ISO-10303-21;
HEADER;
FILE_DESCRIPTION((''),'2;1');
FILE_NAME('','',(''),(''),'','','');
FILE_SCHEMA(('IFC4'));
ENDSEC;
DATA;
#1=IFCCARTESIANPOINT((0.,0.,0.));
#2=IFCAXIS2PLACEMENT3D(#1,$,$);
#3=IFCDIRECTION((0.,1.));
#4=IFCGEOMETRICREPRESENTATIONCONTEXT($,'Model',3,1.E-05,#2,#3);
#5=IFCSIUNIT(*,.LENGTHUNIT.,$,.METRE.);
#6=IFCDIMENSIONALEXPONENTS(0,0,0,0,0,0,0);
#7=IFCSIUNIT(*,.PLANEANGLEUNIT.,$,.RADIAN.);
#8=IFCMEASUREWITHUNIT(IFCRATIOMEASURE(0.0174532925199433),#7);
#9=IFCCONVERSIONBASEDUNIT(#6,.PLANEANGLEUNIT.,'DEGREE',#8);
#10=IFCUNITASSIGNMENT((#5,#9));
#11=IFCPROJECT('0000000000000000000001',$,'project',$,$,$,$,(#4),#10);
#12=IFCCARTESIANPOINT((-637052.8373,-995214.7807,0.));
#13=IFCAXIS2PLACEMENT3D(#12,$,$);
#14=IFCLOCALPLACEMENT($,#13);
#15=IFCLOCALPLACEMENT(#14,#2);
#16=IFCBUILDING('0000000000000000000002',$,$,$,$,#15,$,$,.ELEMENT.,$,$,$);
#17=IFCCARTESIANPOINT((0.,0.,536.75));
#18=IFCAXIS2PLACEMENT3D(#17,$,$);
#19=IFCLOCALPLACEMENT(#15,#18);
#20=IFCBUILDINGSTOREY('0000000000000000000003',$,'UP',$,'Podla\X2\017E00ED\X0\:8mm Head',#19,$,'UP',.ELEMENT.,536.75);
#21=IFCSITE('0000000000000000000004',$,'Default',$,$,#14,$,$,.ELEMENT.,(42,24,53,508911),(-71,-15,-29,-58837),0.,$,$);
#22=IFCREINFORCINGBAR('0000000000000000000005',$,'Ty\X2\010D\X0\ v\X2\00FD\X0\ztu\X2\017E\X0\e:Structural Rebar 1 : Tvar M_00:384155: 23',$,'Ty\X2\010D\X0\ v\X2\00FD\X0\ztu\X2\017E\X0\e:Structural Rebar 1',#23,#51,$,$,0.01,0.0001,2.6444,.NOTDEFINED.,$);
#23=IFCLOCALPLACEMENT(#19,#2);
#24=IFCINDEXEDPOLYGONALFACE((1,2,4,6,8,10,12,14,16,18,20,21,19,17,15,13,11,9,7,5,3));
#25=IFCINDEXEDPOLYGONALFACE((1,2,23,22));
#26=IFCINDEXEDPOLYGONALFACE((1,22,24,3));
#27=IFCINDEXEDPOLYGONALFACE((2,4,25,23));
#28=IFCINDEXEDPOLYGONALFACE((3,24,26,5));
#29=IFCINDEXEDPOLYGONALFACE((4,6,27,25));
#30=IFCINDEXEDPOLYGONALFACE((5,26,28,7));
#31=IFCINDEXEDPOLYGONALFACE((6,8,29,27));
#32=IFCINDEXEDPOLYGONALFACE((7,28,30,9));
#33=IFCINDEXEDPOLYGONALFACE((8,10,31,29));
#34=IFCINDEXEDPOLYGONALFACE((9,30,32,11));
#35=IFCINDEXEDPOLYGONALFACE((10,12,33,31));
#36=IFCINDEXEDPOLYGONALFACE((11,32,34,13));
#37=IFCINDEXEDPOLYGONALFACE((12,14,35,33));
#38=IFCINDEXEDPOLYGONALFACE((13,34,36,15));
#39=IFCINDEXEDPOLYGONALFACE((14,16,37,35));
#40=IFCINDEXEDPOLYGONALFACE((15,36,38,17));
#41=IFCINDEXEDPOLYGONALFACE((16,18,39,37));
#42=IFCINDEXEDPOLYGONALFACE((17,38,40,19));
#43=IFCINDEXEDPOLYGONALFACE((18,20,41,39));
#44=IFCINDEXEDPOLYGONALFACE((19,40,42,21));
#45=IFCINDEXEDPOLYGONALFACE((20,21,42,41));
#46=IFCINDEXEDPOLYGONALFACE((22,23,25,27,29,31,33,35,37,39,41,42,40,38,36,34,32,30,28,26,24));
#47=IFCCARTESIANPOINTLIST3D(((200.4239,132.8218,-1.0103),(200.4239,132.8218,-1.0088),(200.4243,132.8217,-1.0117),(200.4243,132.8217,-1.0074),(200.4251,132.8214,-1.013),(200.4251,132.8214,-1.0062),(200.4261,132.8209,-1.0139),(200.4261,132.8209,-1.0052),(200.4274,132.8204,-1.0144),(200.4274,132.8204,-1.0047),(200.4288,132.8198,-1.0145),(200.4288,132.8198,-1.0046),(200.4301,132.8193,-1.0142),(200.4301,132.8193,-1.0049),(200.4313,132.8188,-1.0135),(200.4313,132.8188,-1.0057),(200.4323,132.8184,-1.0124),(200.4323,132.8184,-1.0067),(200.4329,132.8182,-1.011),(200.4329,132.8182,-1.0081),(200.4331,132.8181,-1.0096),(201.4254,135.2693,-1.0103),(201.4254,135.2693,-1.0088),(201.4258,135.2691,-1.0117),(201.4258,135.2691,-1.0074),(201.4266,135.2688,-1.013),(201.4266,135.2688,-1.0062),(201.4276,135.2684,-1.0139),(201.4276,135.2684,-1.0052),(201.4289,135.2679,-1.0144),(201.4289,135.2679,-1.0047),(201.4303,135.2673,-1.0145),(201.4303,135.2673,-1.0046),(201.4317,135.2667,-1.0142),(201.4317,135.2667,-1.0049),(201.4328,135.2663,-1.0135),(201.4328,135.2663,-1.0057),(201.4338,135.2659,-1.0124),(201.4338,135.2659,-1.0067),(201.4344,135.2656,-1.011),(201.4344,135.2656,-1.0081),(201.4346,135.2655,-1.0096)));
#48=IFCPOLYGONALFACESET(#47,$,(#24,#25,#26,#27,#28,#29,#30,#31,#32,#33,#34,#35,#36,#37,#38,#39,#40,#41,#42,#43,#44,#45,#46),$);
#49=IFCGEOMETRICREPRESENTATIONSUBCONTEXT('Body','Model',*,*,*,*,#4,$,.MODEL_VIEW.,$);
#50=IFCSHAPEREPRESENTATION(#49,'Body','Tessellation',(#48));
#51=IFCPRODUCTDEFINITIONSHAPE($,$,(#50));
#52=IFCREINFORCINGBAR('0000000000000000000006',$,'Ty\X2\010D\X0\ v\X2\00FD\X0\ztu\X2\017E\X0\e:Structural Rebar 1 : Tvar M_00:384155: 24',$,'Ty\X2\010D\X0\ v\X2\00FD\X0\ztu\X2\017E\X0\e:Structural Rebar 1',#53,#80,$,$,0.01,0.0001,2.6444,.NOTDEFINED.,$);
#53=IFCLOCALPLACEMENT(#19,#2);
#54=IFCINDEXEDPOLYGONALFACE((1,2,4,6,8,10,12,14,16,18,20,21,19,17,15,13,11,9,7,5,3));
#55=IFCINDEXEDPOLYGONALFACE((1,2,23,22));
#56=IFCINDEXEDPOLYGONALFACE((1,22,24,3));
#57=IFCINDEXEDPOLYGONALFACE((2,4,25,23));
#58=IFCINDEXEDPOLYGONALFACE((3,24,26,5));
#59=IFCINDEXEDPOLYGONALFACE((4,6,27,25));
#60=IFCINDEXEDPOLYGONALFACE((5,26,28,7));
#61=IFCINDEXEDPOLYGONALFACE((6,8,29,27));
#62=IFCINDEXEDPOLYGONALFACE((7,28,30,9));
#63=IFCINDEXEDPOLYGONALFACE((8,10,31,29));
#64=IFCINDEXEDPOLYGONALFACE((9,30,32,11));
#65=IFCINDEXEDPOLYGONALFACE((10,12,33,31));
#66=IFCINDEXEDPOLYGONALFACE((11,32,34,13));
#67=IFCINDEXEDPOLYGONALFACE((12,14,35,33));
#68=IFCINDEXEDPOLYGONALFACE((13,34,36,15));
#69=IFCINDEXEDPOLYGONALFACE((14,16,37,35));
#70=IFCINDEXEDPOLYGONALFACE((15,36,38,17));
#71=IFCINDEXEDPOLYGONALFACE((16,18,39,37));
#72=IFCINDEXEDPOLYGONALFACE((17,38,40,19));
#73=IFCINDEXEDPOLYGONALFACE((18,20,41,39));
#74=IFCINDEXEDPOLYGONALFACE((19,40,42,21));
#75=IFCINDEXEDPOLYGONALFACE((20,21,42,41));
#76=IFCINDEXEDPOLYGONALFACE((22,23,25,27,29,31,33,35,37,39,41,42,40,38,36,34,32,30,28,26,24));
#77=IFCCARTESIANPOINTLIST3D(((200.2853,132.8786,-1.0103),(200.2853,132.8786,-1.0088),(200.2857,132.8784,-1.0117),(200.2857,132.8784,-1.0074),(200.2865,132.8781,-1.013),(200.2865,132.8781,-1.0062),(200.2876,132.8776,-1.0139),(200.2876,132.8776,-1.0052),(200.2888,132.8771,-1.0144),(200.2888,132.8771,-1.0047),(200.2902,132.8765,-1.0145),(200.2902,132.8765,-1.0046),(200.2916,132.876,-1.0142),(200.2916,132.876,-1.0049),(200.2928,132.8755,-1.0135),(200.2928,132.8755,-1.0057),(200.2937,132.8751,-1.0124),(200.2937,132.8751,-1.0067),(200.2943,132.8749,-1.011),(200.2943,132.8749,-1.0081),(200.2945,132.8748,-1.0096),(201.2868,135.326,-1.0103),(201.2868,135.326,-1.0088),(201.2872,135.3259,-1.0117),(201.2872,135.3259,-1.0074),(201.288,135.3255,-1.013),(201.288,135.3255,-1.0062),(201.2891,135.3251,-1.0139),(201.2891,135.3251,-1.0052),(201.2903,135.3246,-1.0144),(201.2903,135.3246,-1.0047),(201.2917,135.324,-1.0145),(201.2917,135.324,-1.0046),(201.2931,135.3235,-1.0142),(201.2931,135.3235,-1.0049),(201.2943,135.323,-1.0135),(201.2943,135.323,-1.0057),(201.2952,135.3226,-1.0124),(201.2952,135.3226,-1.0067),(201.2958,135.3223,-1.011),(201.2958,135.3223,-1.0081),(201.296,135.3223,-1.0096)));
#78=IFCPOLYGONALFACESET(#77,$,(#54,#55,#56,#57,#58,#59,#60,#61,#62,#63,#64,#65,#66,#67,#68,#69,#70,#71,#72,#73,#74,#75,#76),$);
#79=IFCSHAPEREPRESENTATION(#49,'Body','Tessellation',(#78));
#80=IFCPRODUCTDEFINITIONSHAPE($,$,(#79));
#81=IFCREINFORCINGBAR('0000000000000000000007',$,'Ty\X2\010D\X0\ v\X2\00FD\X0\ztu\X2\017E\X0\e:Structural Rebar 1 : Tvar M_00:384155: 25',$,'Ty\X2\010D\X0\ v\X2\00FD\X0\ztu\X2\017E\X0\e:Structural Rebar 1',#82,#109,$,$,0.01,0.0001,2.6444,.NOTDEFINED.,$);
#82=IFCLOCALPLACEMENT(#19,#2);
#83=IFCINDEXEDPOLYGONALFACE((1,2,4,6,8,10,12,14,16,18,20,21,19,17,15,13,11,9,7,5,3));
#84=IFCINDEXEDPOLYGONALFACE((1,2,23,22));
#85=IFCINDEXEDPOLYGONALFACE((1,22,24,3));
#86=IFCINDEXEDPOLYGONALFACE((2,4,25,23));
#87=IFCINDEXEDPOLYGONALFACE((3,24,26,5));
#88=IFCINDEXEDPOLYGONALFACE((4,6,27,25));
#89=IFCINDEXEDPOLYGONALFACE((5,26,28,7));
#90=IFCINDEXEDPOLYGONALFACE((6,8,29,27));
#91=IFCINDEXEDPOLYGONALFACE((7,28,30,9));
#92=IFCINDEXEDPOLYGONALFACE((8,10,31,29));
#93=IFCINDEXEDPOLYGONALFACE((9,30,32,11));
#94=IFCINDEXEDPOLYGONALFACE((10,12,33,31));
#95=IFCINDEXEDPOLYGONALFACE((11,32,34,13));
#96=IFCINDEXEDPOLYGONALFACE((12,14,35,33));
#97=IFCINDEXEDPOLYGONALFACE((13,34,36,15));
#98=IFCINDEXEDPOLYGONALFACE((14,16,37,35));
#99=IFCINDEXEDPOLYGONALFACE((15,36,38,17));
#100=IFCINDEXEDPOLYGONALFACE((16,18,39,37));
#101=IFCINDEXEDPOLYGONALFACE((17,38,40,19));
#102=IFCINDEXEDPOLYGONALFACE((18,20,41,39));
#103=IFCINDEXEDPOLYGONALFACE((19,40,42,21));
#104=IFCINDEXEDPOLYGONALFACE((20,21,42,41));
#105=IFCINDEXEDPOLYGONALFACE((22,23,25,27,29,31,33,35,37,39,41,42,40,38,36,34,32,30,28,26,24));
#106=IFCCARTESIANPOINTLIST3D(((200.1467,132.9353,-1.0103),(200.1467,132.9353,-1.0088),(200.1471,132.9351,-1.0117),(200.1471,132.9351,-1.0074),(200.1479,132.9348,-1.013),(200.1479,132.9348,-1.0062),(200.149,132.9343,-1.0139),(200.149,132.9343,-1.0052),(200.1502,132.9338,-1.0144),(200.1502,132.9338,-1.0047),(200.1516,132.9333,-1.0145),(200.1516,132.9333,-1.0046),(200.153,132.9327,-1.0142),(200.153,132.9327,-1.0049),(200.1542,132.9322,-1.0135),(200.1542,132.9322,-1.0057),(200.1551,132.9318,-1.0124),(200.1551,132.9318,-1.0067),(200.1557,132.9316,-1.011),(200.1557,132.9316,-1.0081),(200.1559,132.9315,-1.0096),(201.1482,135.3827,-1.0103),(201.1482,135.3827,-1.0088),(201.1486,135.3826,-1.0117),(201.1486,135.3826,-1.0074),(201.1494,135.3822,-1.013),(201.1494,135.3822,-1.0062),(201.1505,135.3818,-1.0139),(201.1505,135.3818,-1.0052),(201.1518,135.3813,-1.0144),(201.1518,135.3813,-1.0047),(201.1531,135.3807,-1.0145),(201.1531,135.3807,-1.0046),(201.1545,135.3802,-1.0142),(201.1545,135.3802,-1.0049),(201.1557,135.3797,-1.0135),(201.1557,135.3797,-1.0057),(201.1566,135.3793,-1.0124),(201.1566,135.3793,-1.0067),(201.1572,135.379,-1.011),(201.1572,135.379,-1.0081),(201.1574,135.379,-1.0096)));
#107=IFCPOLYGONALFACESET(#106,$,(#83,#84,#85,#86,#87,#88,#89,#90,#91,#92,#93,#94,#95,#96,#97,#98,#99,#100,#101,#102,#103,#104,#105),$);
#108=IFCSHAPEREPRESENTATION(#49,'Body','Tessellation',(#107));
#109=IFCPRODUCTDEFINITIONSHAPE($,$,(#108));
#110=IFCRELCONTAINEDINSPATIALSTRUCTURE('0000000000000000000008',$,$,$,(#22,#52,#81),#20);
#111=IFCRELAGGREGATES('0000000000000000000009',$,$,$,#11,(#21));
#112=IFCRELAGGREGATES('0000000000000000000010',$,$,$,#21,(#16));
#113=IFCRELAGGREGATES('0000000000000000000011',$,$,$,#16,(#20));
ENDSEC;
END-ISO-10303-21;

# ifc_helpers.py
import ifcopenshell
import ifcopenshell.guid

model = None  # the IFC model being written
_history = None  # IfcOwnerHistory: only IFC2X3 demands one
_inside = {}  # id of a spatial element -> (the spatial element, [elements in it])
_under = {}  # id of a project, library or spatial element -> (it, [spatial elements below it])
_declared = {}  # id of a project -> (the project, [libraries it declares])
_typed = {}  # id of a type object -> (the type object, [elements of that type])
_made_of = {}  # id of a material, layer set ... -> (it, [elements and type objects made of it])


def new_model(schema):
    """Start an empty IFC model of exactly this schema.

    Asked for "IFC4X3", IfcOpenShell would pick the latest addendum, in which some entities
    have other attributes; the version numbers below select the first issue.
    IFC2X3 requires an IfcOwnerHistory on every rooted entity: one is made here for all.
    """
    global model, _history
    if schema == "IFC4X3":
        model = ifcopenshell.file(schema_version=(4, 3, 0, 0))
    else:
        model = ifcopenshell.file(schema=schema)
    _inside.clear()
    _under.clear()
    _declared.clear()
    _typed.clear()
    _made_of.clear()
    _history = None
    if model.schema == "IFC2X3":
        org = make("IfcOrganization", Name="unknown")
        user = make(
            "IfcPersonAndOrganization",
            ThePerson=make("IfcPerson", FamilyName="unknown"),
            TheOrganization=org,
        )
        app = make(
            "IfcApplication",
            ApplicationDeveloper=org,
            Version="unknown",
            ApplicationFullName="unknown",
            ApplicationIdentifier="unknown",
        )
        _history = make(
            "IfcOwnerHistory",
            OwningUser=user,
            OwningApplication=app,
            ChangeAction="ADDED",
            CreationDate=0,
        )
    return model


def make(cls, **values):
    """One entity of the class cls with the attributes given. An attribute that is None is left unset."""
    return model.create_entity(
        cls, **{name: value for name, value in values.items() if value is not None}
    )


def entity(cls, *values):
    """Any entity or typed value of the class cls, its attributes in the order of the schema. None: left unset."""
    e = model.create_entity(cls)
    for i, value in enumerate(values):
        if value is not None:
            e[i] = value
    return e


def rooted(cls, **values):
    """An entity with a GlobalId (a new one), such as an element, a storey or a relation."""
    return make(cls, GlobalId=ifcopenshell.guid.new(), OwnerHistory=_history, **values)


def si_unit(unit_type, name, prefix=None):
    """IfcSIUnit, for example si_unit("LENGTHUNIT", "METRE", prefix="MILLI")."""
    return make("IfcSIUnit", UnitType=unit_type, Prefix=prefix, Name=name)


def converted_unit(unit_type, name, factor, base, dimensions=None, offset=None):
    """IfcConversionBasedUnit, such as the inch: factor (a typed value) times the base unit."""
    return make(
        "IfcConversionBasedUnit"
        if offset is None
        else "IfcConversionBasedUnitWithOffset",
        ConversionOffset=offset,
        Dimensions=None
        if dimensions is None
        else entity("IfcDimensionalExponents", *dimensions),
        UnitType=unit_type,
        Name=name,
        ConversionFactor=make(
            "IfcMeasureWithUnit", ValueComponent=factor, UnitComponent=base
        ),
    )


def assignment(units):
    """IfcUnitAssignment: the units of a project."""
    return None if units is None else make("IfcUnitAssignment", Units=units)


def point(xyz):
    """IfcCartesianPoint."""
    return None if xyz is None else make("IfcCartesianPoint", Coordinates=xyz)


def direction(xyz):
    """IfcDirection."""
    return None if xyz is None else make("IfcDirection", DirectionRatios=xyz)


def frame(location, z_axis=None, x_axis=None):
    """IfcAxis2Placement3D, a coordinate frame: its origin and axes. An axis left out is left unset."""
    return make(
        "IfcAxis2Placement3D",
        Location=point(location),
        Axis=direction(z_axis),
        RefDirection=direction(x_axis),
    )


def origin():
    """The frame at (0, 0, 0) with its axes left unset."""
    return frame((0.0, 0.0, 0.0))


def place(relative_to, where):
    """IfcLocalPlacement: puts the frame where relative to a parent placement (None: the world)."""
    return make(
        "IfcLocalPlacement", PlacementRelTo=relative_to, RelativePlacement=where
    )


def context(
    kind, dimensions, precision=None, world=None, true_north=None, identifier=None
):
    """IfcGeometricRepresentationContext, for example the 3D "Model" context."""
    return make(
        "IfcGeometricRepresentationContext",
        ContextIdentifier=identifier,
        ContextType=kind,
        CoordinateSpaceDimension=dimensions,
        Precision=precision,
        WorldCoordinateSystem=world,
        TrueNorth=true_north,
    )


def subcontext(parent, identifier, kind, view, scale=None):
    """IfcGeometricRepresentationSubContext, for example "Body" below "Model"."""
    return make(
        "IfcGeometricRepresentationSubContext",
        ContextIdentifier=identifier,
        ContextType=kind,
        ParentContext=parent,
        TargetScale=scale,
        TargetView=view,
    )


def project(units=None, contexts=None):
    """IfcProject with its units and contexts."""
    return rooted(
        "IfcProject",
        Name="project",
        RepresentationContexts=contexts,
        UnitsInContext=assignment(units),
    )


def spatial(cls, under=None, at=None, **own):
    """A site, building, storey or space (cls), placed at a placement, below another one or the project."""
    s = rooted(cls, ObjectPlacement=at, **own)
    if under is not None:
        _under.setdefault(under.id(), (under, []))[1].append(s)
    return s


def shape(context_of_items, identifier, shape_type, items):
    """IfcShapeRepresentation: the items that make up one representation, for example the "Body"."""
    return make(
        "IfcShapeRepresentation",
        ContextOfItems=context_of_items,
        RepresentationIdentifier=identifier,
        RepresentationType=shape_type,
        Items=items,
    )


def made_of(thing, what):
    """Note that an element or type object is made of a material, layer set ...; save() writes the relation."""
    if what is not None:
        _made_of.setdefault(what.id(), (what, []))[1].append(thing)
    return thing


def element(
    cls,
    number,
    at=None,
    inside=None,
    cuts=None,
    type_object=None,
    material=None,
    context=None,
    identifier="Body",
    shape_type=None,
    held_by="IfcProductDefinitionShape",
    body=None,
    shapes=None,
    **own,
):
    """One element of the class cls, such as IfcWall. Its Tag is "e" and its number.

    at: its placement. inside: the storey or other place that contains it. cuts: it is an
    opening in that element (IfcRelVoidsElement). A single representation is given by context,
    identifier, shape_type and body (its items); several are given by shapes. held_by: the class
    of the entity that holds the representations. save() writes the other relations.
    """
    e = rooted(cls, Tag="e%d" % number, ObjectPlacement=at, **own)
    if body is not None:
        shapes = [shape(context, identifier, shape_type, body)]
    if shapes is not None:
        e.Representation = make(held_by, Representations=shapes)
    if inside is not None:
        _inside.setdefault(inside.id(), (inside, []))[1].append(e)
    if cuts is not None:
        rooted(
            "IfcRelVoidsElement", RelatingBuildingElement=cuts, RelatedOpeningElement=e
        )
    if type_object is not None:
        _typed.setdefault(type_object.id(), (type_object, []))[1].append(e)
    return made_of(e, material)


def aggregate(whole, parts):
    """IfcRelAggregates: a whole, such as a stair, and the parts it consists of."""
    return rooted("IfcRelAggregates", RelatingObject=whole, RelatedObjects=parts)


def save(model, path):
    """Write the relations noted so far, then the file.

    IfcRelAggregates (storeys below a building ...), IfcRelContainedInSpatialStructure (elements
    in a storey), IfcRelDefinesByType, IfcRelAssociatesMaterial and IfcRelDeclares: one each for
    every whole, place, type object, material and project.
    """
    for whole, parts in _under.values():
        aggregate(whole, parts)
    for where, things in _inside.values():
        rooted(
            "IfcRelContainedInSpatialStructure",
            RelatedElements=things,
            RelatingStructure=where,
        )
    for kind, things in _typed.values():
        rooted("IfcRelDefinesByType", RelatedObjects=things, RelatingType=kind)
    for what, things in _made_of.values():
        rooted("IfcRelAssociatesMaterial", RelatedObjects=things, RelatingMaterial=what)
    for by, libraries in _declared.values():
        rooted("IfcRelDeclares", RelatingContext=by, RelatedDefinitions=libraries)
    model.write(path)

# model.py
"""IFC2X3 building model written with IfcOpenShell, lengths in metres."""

from ifc_helpers import new_model, entity, si_unit, converted_unit, direction, frame, origin, place, context, subcontext, project, spatial, element, save


model = new_model("IFC2X3")

# Units and contexts
model_context = context("Model", 3, precision=1e-05, world=origin(), true_north=direction((0.0, 1.0)))
body_context = subcontext(model_context, "Body", "Model", "MODEL_VIEW")
ifc_project = project(units=[si_unit("LENGTHUNIT", "METRE"), converted_unit("PLANEANGLEUNIT", "DEGREE", entity("IfcRatioMeasure", 0.0174532925199433), si_unit("PLANEANGLEUNIT", "RADIAN"), dimensions=[0, 0, 0, 0, 0, 0, 0])], contexts=[model_context])

# Site, building, storey
site_placement = place(None, frame((-637052.8373, -995214.7807, 0.0)))
site = spatial("IfcSite", under=ifc_project, at=site_placement, Name="Default", CompositionType="ELEMENT", RefLatitude=(42, 24, 53, 508911), RefLongitude=(-71, -15, -29, -58837), RefElevation=0.0)
building_placement = place(site_placement, origin())
building = spatial("IfcBuilding", under=site, at=building_placement, CompositionType="ELEMENT")
storey_placement = place(building_placement, frame((0.0, 0.0, 536.75)))
storey = spatial("IfcBuildingStorey", under=building, at=storey_placement, Name="UP", ObjectType="Podlaží:8mm Head", LongName="UP", CompositionType="ELEMENT", Elevation=536.75)

# Reinforcing bars
reinforcing_bar_1_placement = place(storey_placement, origin())
element("IfcReinforcingBar", 1, at=reinforcing_bar_1_placement, inside=storey, Name="Tyč výztuže:Structural Rebar 1 : Tvar M_00:384155: 23", ObjectType="Tyč výztuže:Structural Rebar 1", BarLength=2.6444, BarRole="NOTDEFINED", CrossSectionArea=0.0001, NominalDiameter=0.01, context=body_context, shape_type="AdvancedSweptSolid", body=[
    entity("IfcSweptDiskSolid", entity("IfcCompositeCurve", [entity("IfcCompositeCurveSegment", "CONTINUOUS", True, entity("IfcPolyline", [entity("IfcCartesianPoint", [-201.43, -135.2674, 1.0096]), entity("IfcCartesianPoint", [-200.4285, -132.82, 1.0096])]))], False), 0.005, None, 0.0, 1.0),
])
reinforcing_bar_2_placement = place(storey_placement, origin())
element("IfcReinforcingBar", 2, at=reinforcing_bar_2_placement, inside=storey, Name="Tyč výztuže:Structural Rebar 1 : Tvar M_00:384155: 24", ObjectType="Tyč výztuže:Structural Rebar 1", BarLength=2.6444, BarRole="NOTDEFINED", CrossSectionArea=0.0001, NominalDiameter=0.01, context=body_context, shape_type="AdvancedSweptSolid", body=[
    entity("IfcSweptDiskSolid", entity("IfcCompositeCurve", [entity("IfcCompositeCurveSegment", "CONTINUOUS", True, entity("IfcPolyline", [entity("IfcCartesianPoint", [-201.2914, -135.3241, 1.0096]), entity("IfcCartesianPoint", [-200.2899, -132.8767, 1.0096])]))], False), 0.005, None, 0.0, 1.0),
])
reinforcing_bar_3_placement = place(storey_placement, origin())
element("IfcReinforcingBar", 3, at=reinforcing_bar_3_placement, inside=storey, Name="Tyč výztuže:Structural Rebar 1 : Tvar M_00:384155: 25", ObjectType="Tyč výztuže:Structural Rebar 1", BarLength=2.6444, BarRole="NOTDEFINED", CrossSectionArea=0.0001, NominalDiameter=0.01, context=body_context, shape_type="AdvancedSweptSolid", body=[
    entity("IfcSweptDiskSolid", entity("IfcCompositeCurve", [entity("IfcCompositeCurveSegment", "CONTINUOUS", True, entity("IfcPolyline", [entity("IfcCartesianPoint", [-201.1528, -135.3809, 1.0096]), entity("IfcCartesianPoint", [-200.1513, -132.9334, 1.0096])]))], False), 0.005, None, 0.0, 1.0),
])

save(model, "model.ifc")
